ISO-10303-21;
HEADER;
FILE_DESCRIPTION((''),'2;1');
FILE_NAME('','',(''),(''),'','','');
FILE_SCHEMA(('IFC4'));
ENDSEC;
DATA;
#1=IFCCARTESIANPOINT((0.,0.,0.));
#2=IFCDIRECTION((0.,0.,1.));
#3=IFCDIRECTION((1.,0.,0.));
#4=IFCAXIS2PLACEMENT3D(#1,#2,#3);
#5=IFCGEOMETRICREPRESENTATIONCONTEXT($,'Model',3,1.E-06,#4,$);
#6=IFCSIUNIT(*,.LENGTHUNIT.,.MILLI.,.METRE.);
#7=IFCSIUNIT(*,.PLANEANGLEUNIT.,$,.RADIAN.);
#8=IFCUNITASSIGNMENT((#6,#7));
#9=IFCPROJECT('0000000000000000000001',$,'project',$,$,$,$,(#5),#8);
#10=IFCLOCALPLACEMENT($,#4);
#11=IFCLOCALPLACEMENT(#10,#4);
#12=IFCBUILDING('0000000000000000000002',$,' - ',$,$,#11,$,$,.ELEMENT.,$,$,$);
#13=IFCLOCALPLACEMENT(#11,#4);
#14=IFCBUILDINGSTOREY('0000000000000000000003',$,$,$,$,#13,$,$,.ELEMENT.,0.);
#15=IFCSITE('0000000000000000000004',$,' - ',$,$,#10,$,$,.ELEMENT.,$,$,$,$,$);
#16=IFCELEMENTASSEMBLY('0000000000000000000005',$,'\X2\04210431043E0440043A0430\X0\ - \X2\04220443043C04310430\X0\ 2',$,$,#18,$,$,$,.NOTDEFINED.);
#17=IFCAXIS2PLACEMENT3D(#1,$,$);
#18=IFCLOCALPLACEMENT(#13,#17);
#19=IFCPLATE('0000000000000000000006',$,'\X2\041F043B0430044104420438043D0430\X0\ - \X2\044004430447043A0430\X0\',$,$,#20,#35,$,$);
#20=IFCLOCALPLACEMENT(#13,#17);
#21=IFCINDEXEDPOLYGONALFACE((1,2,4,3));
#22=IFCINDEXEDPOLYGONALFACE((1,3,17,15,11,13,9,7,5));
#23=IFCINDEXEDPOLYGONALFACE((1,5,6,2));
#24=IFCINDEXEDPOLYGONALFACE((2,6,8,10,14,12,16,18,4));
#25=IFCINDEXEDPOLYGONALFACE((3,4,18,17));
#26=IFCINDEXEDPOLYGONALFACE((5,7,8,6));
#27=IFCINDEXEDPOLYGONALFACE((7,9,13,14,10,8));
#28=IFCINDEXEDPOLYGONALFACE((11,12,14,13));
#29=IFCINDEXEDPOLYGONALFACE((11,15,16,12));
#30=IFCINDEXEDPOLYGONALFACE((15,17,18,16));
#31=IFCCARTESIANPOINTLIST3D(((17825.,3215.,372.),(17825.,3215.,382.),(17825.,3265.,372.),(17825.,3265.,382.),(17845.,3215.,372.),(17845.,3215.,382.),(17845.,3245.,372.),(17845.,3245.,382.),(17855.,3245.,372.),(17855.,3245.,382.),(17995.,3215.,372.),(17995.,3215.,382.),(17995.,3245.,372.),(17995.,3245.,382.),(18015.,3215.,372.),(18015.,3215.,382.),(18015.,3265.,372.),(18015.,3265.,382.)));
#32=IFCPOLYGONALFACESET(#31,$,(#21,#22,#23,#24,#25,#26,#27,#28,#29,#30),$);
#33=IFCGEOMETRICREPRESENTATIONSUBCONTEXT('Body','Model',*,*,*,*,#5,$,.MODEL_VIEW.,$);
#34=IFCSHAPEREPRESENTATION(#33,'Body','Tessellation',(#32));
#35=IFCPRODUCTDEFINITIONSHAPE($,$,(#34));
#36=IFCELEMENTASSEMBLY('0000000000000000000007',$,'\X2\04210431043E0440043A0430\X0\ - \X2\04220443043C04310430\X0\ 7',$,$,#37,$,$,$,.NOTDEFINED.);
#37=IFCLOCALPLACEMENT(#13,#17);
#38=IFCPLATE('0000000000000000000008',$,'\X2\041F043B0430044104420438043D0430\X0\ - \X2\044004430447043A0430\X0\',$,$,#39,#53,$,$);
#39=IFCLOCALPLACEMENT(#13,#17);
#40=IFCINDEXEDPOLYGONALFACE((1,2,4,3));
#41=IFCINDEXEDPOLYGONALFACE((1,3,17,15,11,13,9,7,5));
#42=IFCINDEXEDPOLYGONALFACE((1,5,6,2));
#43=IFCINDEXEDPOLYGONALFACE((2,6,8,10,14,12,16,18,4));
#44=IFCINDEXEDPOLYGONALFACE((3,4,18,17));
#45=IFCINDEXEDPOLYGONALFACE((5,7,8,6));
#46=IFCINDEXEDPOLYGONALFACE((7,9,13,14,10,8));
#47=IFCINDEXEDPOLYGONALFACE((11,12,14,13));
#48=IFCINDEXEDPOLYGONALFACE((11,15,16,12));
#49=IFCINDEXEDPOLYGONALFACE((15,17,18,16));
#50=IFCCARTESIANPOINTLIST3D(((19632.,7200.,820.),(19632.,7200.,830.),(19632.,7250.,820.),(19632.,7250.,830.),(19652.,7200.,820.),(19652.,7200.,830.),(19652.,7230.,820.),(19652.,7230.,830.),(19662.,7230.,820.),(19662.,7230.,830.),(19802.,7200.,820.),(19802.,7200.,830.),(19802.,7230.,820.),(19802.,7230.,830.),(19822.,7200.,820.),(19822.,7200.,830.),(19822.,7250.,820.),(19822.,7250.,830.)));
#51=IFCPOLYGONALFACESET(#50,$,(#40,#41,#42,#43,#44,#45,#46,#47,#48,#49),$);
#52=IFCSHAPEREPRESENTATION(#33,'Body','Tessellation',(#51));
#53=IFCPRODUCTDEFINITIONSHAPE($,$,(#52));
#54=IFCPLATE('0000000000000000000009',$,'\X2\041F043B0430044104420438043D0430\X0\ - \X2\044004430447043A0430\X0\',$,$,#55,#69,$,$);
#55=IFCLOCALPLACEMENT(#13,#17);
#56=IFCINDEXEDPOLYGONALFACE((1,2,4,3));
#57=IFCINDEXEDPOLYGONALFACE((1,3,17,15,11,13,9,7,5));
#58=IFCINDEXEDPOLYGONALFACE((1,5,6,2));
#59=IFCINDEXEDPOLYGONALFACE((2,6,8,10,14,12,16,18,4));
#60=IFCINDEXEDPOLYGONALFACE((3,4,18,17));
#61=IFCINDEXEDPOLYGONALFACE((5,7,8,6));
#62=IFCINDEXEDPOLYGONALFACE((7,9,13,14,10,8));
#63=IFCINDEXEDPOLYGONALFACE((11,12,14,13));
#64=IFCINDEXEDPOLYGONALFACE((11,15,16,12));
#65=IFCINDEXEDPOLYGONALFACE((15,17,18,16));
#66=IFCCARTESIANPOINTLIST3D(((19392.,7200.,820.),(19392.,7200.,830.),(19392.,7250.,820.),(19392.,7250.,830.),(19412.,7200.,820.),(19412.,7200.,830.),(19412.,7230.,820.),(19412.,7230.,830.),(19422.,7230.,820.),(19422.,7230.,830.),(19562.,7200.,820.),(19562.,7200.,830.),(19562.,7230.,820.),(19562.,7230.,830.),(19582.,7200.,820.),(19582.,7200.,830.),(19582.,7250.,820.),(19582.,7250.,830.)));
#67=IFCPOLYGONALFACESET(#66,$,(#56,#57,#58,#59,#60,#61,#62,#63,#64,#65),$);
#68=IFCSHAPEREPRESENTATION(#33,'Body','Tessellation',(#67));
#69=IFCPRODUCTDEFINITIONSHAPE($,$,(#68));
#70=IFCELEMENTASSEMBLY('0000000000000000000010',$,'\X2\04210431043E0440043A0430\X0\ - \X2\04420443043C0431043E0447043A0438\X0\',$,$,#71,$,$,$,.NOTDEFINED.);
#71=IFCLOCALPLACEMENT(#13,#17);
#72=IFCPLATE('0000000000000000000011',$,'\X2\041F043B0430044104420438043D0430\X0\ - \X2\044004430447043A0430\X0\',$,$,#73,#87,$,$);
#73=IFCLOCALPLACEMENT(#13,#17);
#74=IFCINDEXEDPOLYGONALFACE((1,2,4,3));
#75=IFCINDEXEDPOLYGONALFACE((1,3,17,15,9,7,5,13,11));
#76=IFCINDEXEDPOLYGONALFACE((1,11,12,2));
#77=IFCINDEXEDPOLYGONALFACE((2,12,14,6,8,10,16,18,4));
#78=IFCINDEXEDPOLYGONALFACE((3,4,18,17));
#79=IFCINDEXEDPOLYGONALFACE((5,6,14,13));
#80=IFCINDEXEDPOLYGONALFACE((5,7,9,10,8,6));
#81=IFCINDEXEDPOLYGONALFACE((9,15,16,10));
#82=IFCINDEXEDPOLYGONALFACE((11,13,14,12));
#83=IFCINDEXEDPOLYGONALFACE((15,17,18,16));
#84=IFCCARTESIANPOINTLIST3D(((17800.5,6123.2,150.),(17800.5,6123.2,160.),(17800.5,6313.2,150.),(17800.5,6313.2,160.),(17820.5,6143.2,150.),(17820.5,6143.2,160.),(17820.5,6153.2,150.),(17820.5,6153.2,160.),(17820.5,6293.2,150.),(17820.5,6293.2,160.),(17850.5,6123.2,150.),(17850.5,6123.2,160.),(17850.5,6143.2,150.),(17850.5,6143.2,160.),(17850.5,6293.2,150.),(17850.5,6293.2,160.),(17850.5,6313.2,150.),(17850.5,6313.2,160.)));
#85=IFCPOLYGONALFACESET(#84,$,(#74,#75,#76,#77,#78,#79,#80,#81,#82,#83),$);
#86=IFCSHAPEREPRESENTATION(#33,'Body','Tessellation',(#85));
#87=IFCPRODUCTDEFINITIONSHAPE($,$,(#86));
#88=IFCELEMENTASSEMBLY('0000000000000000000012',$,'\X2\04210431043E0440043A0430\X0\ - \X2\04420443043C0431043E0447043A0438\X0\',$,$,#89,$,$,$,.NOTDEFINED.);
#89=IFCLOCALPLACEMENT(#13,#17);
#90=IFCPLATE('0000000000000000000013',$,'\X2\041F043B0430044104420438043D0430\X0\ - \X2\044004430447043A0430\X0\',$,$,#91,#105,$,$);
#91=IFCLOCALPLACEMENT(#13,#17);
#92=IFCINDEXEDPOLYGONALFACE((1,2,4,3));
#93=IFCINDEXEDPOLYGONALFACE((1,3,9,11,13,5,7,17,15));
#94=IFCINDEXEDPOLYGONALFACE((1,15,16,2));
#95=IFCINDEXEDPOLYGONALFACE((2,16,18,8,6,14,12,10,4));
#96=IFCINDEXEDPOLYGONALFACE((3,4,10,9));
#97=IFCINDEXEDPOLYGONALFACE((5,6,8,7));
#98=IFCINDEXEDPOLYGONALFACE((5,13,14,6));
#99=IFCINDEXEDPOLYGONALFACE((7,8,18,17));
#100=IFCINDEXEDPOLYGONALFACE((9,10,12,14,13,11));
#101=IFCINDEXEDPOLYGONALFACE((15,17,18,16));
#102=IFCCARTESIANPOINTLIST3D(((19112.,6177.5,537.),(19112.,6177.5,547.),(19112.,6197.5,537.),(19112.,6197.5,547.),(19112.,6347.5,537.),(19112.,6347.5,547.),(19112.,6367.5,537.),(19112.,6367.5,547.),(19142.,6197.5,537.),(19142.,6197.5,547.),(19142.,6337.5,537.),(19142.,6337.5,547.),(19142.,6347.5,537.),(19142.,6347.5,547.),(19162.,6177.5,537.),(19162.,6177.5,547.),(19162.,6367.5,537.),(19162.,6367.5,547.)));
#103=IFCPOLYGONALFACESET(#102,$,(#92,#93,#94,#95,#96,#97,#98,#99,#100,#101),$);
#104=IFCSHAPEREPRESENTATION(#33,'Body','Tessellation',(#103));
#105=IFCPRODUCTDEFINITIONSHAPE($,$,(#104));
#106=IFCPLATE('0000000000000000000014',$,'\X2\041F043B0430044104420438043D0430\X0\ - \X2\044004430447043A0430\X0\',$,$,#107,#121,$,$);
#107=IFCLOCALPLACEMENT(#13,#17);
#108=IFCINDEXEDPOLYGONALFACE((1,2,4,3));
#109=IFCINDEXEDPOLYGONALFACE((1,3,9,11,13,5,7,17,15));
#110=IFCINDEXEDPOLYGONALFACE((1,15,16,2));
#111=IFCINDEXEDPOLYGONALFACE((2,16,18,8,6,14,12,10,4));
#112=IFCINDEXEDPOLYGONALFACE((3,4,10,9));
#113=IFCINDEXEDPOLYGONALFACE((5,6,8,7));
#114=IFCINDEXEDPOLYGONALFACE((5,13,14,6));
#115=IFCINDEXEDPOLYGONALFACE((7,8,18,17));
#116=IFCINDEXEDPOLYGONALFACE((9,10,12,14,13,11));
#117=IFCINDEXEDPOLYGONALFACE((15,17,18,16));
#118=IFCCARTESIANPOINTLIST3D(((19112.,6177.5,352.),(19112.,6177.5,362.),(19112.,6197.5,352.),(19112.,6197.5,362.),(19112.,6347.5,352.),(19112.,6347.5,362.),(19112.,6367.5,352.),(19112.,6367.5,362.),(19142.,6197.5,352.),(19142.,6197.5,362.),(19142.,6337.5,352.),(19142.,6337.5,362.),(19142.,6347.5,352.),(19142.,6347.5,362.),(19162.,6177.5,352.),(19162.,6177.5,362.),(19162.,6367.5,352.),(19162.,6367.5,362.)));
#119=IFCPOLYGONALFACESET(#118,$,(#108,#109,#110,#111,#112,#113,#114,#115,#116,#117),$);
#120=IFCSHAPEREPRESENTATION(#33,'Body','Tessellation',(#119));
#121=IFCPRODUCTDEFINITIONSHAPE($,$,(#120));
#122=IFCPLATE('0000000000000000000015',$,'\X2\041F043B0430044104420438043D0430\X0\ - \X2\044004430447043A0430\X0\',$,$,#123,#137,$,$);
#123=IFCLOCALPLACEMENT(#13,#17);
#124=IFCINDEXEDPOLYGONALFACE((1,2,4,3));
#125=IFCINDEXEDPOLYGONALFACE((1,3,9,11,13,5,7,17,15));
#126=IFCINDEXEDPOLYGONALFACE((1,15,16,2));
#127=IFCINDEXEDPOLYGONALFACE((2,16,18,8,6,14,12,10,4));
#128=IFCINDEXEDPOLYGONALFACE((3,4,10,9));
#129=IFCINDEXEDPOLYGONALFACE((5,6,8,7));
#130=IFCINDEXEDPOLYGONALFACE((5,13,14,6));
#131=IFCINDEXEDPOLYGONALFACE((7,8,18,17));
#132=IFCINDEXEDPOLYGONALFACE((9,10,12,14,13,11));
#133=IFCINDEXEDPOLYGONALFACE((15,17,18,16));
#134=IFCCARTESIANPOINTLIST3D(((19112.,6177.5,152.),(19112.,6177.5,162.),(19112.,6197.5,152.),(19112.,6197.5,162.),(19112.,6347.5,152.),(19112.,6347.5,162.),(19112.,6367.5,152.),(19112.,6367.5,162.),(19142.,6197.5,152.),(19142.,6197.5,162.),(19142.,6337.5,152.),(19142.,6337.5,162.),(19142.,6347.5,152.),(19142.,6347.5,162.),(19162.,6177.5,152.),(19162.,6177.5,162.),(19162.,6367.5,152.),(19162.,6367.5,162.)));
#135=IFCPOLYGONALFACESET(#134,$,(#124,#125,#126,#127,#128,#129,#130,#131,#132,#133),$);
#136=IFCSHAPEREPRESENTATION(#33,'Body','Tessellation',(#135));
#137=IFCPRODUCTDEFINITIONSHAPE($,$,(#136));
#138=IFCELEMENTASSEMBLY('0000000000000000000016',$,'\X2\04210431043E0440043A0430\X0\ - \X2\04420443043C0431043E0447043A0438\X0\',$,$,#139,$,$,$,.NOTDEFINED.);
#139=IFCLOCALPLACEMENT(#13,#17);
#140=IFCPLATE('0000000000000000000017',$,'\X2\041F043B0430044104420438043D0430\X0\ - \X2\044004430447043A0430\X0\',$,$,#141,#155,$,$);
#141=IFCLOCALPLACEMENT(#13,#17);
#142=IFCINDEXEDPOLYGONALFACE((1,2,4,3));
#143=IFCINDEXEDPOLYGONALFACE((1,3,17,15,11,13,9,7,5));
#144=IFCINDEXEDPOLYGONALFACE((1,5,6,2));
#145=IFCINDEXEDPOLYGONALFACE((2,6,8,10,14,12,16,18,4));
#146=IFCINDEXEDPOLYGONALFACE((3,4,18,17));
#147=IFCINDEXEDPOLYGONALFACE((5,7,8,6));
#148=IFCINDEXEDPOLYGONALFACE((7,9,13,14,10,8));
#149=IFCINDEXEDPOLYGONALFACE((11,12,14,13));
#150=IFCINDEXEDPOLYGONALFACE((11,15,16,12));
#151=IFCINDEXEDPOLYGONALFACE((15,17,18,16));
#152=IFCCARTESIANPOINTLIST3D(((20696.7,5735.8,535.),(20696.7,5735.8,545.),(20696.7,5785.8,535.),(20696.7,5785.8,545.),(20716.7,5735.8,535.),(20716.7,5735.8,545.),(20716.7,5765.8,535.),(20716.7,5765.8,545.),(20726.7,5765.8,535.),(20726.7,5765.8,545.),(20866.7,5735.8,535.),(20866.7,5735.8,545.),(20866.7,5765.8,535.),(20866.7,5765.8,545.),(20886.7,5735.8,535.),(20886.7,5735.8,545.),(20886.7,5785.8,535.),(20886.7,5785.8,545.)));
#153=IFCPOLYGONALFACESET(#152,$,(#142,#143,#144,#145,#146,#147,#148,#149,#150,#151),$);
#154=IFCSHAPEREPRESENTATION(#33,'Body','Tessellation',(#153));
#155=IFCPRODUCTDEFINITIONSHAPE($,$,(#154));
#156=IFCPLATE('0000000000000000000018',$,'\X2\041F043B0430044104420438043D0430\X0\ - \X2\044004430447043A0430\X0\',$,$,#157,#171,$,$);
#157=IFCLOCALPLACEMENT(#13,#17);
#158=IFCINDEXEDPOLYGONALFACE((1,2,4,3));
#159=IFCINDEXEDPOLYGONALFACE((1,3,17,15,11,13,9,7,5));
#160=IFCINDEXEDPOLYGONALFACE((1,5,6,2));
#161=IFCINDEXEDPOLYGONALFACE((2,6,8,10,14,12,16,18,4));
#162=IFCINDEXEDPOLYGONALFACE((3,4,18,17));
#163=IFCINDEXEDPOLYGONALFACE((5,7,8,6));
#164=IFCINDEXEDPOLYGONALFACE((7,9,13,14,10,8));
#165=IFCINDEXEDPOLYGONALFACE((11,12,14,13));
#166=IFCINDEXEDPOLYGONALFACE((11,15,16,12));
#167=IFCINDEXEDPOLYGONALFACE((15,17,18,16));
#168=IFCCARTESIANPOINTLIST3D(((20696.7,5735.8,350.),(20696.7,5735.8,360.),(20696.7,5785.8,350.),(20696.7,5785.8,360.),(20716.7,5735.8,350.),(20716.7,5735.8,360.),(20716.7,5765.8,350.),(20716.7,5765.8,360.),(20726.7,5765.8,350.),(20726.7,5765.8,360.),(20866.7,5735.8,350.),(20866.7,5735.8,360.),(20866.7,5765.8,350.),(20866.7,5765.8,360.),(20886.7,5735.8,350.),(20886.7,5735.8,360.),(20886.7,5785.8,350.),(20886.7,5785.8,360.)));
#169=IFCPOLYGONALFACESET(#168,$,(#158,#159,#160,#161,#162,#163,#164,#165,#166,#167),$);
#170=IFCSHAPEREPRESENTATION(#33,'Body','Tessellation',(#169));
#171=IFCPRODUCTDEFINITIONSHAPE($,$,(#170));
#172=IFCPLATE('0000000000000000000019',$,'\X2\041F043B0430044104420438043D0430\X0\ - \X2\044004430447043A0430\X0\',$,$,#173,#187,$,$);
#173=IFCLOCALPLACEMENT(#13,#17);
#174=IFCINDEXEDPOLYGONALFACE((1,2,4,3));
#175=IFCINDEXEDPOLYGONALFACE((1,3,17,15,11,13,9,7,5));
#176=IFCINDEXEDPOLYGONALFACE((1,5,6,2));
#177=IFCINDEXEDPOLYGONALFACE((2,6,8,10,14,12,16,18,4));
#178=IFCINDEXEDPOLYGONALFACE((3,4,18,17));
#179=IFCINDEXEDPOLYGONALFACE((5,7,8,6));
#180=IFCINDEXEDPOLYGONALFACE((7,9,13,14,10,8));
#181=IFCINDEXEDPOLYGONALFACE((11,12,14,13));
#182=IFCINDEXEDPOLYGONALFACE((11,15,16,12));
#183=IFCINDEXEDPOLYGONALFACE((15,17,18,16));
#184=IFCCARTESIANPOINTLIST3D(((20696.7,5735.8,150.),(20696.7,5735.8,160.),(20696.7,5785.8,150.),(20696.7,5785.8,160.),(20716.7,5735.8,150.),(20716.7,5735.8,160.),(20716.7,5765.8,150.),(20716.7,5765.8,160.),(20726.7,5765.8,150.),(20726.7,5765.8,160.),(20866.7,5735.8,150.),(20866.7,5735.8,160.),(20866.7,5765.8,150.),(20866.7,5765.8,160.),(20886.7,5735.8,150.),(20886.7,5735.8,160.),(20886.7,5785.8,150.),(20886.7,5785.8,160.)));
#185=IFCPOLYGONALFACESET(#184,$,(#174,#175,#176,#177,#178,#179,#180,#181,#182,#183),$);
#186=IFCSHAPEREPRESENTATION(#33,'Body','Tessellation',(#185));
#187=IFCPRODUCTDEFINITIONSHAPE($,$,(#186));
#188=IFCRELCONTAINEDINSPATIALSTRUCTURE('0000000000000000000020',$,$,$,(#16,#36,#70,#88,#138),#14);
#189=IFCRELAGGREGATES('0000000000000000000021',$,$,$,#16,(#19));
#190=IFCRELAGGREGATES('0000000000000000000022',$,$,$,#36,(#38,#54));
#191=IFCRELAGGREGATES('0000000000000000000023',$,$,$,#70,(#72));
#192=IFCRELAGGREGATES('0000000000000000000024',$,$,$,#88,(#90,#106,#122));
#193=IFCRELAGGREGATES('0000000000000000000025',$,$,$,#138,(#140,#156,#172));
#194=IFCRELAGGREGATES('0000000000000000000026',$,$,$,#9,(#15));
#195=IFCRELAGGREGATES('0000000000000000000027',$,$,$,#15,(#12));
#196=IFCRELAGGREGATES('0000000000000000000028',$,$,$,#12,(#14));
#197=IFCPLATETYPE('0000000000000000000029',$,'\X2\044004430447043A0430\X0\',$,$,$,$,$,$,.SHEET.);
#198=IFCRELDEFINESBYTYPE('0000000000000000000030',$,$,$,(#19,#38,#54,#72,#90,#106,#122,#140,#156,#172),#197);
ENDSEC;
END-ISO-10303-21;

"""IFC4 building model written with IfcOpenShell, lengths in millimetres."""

from ifc_helpers import new_model, si_unit, frame, origin_with_axes, place, context, subcontext, project, spatial, line, indexed_curve, outline, extrude, source, transform, mapped, type_object, element, aggregate, save


model = new_model("IFC4")

# Units and contexts
model_context = context("Model", 3, precision=1e-06, world=origin_with_axes())
body_context = subcontext(model_context, "Body", "Model", "MODEL_VIEW")
ifc_project = project(units=[si_unit("LENGTHUNIT", "METRE", prefix="MILLI"), si_unit("PLANEANGLEUNIT", "RADIAN")], contexts=[model_context])

# Site, building, storey
site_placement = place(None, origin_with_axes())
site = spatial("IfcSite", under=ifc_project, at=site_placement, Name=" - ", CompositionType="ELEMENT")
building_placement = place(site_placement, origin_with_axes())
building = spatial("IfcBuilding", under=site, at=building_placement, Name=" - ", CompositionType="ELEMENT")
storey_placement = place(building_placement, origin_with_axes())
storey = spatial("IfcBuildingStorey", under=building, at=storey_placement, CompositionType="ELEMENT", Elevation=0.0)

# Element assemblies, plates
assembly_1_placement = place(storey_placement, frame((17920.0, 3000.0, 2.0), z_axis=(0.0, 0.0, 1.0), x_axis=(-1.0, 0.0, 0.0)))
assembly_1 = element("IfcElementAssembly", 1, at=assembly_1_placement, inside=storey, Name="Сборка - Тумба 2", PredefinedType="NOTDEFINED")
plate_type = type_object("IfcPlateType", Name="ручка", PredefinedType="SHEET")
shared_shape = source(origin_with_axes(), body_context, "Body", "SweptSolid", [
    extrude(outline(indexed_curve([(-95.0, -25.0), (-75.0, -25.0), (-75.0, 5.0), (-65.0, 5.0), (75.0, 5.0), (75.0, -25.0), (95.0, -25.0), (95.0, 25.0), (-95.0, 25.0)], segments=[line(1, 2), line(2, 3), line(3, 4), line(4, 5), line(5, 6), line(6, 7), line(7, 8), line(8, 9), line(9, 1)])), origin_with_axes(), (0.0, 0.0, 1.0), 10.0),
])
plate_1_placement = place(assembly_1_placement, frame((0.0, -240.0, 370.0), z_axis=(0.0, 0.0, 1.0), x_axis=(-1.0, 0.0, 0.0)))
plate_1 = element("IfcPlate", 2, at=plate_1_placement, type_object=plate_type, Name="Пластина - ручка", context=body_context, shape_type="MappedRepresentation", body=[
    mapped(shared_shape, transform((0.0, 0.0, 0.0), x_axis=(1.0, 0.0, 0.0), y_axis=(0.0, 1.0, 0.0), z_axis=(0.0, 0.0, 1.0), scale=1.0)),
])
aggregate(assembly_1, [plate_1])
assembly_2_placement = place(storey_placement, frame((19607.0, 6985.0, 0.0), z_axis=(0.0, 0.0, 1.0), x_axis=(-1.0, 0.0, 0.0)))
assembly_2 = element("IfcElementAssembly", 3, at=assembly_2_placement, inside=storey, Name="Сборка - Тумба 7", PredefinedType="NOTDEFINED")
plate_2_placement = place(assembly_2_placement, frame((-120.0, -240.0, 820.0), z_axis=(0.0, 0.0, 1.0), x_axis=(-1.0, 0.0, 0.0)))
plate_2 = element("IfcPlate", 4, at=plate_2_placement, type_object=plate_type, Name="Пластина - ручка", context=body_context, shape_type="MappedRepresentation", body=[
    mapped(shared_shape, transform((0.0, 0.0, 0.0), x_axis=(1.0, 0.0, 0.0), y_axis=(0.0, 1.0, 0.0), z_axis=(0.0, 0.0, 1.0), scale=1.0)),
])
plate_3_placement = place(assembly_2_placement, frame((120.0, -240.0, 820.0), z_axis=(0.0, 0.0, 1.0), x_axis=(-1.0, 0.0, 0.0)))
plate_3 = element("IfcPlate", 5, at=plate_3_placement, type_object=plate_type, Name="Пластина - ручка", context=body_context, shape_type="MappedRepresentation", body=[
    mapped(shared_shape, transform((0.0, 0.0, 0.0), x_axis=(1.0, 0.0, 0.0), y_axis=(0.0, 1.0, 0.0), z_axis=(0.0, 0.0, 1.0), scale=1.0)),
])
aggregate(assembly_2, [plate_2, plate_3])

# Element assembly, plate
assembly_3_placement = place(storey_placement, frame((17850.5, 6418.2, 0.0), z_axis=(0.0, 0.0, 1.0), x_axis=(0.0, -1.0, 0.0)))
assembly_3 = element("IfcElementAssembly", 6, at=assembly_3_placement, inside=storey, Name="Сборка - тумбочки", PredefinedType="NOTDEFINED")
plate_4_placement = place(assembly_3_placement, frame((200.0, -25.0, 150.0), z_axis=(0.0, 0.0, 1.0), x_axis=(-1.0, 0.0, 0.0)))
plate_4 = element("IfcPlate", 7, at=plate_4_placement, type_object=plate_type, Name="Пластина - ручка", context=body_context, shape_type="MappedRepresentation", body=[
    mapped(shared_shape, transform((0.0, 0.0, 0.0), x_axis=(1.0, 0.0, 0.0), y_axis=(0.0, 1.0, 0.0), z_axis=(0.0, 0.0, 1.0), scale=1.0)),
])
aggregate(assembly_3, [plate_4])

# Element assemblies, plates
assembly_4_placement = place(storey_placement, frame((19112.0, 6072.5, 2.0), z_axis=(0.0, 0.0, 1.0), x_axis=(0.0, 1.0, 0.0)))
assembly_4 = element("IfcElementAssembly", 8, at=assembly_4_placement, inside=storey, Name="Сборка - тумбочки", PredefinedType="NOTDEFINED")
plate_5_placement = place(assembly_4_placement, frame((200.0, -25.0, 535.0), z_axis=(0.0, 0.0, 1.0), x_axis=(-1.0, 0.0, 0.0)))
plate_5 = element("IfcPlate", 9, at=plate_5_placement, type_object=plate_type, Name="Пластина - ручка", context=body_context, shape_type="MappedRepresentation", body=[
    mapped(shared_shape, transform((0.0, 0.0, 0.0), x_axis=(1.0, 0.0, 0.0), y_axis=(0.0, 1.0, 0.0), z_axis=(0.0, 0.0, 1.0), scale=1.0)),
])
plate_6_placement = place(assembly_4_placement, frame((200.0, -25.0, 350.0), z_axis=(0.0, 0.0, 1.0), x_axis=(-1.0, 0.0, 0.0)))
plate_6 = element("IfcPlate", 10, at=plate_6_placement, type_object=plate_type, Name="Пластина - ручка", context=body_context, shape_type="MappedRepresentation", body=[
    mapped(shared_shape, transform((0.0, 0.0, 0.0), x_axis=(1.0, 0.0, 0.0), y_axis=(0.0, 1.0, 0.0), z_axis=(0.0, 0.0, 1.0), scale=1.0)),
])
plate_7_placement = place(assembly_4_placement, frame((200.0, -25.0, 150.0), z_axis=(0.0, 0.0, 1.0), x_axis=(-1.0, 0.0, 0.0)))
plate_7 = element("IfcPlate", 11, at=plate_7_placement, type_object=plate_type, Name="Пластина - ручка", context=body_context, shape_type="MappedRepresentation", body=[
    mapped(shared_shape, transform((0.0, 0.0, 0.0), x_axis=(1.0, 0.0, 0.0), y_axis=(0.0, 1.0, 0.0), z_axis=(0.0, 0.0, 1.0), scale=1.0)),
])
aggregate(assembly_4, [plate_5, plate_6, plate_7])
assembly_5_placement = place(storey_placement, frame((20991.7, 5735.8, 0.0), z_axis=(0.0, 0.0, 1.0), x_axis=(-1.0, 0.0, 0.0)))
assembly_5 = element("IfcElementAssembly", 12, at=assembly_5_placement, inside=storey, Name="Сборка - тумбочки", PredefinedType="NOTDEFINED")
plate_8_placement = place(assembly_5_placement, frame((200.0, -25.0, 535.0), z_axis=(0.0, 0.0, 1.0), x_axis=(-1.0, 0.0, 0.0)))
plate_8 = element("IfcPlate", 13, at=plate_8_placement, type_object=plate_type, Name="Пластина - ручка", context=body_context, shape_type="MappedRepresentation", body=[
    mapped(shared_shape, transform((0.0, 0.0, 0.0), x_axis=(1.0, 0.0, 0.0), y_axis=(0.0, 1.0, 0.0), z_axis=(0.0, 0.0, 1.0), scale=1.0)),
])
plate_9_placement = place(assembly_5_placement, frame((200.0, -25.0, 350.0), z_axis=(0.0, 0.0, 1.0), x_axis=(-1.0, 0.0, 0.0)))
plate_9 = element("IfcPlate", 14, at=plate_9_placement, type_object=plate_type, Name="Пластина - ручка", context=body_context, shape_type="MappedRepresentation", body=[
    mapped(shared_shape, transform((0.0, 0.0, 0.0), x_axis=(1.0, 0.0, 0.0), y_axis=(0.0, 1.0, 0.0), z_axis=(0.0, 0.0, 1.0), scale=1.0)),
])
plate_10_placement = place(assembly_5_placement, frame((200.0, -25.0, 150.0), z_axis=(0.0, 0.0, 1.0), x_axis=(-1.0, 0.0, 0.0)))
plate_10 = element("IfcPlate", 15, at=plate_10_placement, type_object=plate_type, Name="Пластина - ручка", context=body_context, shape_type="MappedRepresentation", body=[
    mapped(shared_shape, transform((0.0, 0.0, 0.0), x_axis=(1.0, 0.0, 0.0), y_axis=(0.0, 1.0, 0.0), z_axis=(0.0, 0.0, 1.0), scale=1.0)),
])
aggregate(assembly_5, [plate_8, plate_9, plate_10])

save(model, "model.ifc")
